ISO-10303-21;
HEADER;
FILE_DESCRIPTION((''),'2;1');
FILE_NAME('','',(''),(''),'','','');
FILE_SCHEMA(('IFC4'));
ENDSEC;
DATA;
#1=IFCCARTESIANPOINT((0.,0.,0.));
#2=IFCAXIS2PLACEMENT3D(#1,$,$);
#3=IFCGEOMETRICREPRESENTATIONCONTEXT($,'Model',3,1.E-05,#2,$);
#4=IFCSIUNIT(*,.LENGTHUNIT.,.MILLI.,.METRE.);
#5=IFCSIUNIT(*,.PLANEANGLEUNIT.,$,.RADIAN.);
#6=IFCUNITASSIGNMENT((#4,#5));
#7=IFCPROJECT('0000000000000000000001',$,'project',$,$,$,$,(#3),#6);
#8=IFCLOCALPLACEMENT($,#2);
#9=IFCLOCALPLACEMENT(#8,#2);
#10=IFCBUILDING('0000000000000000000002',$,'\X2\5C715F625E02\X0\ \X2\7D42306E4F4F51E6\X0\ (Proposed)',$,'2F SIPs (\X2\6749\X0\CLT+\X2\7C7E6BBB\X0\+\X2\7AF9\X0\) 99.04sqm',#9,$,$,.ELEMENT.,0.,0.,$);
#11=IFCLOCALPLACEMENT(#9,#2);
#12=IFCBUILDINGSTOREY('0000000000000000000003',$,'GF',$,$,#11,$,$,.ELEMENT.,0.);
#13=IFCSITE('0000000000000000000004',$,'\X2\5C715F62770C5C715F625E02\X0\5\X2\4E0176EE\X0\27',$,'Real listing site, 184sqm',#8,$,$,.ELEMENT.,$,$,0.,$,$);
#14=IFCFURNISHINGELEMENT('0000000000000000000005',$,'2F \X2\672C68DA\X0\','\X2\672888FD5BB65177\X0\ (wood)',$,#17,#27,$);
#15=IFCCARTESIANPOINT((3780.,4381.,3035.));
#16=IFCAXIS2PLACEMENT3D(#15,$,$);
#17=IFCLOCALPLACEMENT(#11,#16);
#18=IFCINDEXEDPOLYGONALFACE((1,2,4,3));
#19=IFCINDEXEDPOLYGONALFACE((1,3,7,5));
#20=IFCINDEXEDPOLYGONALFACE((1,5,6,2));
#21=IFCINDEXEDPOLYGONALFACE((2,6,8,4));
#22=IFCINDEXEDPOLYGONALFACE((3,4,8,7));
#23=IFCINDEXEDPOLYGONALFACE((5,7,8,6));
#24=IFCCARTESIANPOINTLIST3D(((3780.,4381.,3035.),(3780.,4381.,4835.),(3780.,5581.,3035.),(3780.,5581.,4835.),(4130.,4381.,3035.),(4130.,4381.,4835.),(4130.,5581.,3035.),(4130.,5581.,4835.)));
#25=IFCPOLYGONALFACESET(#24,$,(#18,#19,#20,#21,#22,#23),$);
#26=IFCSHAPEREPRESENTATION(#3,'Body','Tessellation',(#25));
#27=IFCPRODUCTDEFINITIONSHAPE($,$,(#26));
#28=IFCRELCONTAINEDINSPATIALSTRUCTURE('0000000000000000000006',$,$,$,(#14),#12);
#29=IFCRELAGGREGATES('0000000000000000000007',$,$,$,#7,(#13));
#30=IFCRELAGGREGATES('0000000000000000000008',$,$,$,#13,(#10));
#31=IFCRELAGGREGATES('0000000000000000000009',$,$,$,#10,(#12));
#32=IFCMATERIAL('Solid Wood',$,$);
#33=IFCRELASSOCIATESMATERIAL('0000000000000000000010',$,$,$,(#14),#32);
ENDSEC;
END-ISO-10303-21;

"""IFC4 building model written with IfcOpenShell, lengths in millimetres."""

from ifc_helpers import new_model, si_unit, frame, frame_2d, origin, place, context, project, spatial, rectangle, extrude, material, element, save


model = new_model("IFC4")

# Units and contexts
model_context = context("Model", 3, precision=1e-05, world=origin())
ifc_project = project(units=[si_unit("LENGTHUNIT", "METRE", prefix="MILLI"), si_unit("PLANEANGLEUNIT", "RADIAN")], contexts=[model_context])

# Site, building, storey
site_placement = place(None, origin())
site = spatial("IfcSite", under=ifc_project, at=site_placement, Name="山形県山形市5丁目27", ObjectType="Real listing site, 184sqm", CompositionType="ELEMENT", RefElevation=0.0)
building_placement = place(site_placement, origin())
building = spatial("IfcBuilding", under=site, at=building_placement, Name="山形市 終の住処 (Proposed)", ObjectType="2F SIPs (杉CLT+籾殻+竹) 99.04sqm", CompositionType="ELEMENT", ElevationOfRefHeight=0.0, ElevationOfTerrain=0.0)
storey_placement = place(building_placement, origin())
storey = spatial("IfcBuildingStorey", under=building, at=storey_placement, Name="GF", CompositionType="ELEMENT", Elevation=0.0)

# Shared definitions
ifc_material_1 = material(Name="Solid Wood")

# Furnishing element
furnishing_placement = place(storey_placement, frame((3780.0, 4381.0, 3035.0)))
element("IfcFurnishingElement", 1, at=furnishing_placement, inside=storey, material=ifc_material_1, Name="2F 本棚", Description="木製家具 (wood)", context=model_context, shape_type="SweptSolid", body=[
    extrude(rectangle(XDim=350.0, YDim=1200.0, at=frame_2d((175.0, 600.0))), frame((3780.0, 4381.0, 3035.0)), (0.0, 0.0, 1.0), 1800.0),
])

save(model, "model.ifc")
